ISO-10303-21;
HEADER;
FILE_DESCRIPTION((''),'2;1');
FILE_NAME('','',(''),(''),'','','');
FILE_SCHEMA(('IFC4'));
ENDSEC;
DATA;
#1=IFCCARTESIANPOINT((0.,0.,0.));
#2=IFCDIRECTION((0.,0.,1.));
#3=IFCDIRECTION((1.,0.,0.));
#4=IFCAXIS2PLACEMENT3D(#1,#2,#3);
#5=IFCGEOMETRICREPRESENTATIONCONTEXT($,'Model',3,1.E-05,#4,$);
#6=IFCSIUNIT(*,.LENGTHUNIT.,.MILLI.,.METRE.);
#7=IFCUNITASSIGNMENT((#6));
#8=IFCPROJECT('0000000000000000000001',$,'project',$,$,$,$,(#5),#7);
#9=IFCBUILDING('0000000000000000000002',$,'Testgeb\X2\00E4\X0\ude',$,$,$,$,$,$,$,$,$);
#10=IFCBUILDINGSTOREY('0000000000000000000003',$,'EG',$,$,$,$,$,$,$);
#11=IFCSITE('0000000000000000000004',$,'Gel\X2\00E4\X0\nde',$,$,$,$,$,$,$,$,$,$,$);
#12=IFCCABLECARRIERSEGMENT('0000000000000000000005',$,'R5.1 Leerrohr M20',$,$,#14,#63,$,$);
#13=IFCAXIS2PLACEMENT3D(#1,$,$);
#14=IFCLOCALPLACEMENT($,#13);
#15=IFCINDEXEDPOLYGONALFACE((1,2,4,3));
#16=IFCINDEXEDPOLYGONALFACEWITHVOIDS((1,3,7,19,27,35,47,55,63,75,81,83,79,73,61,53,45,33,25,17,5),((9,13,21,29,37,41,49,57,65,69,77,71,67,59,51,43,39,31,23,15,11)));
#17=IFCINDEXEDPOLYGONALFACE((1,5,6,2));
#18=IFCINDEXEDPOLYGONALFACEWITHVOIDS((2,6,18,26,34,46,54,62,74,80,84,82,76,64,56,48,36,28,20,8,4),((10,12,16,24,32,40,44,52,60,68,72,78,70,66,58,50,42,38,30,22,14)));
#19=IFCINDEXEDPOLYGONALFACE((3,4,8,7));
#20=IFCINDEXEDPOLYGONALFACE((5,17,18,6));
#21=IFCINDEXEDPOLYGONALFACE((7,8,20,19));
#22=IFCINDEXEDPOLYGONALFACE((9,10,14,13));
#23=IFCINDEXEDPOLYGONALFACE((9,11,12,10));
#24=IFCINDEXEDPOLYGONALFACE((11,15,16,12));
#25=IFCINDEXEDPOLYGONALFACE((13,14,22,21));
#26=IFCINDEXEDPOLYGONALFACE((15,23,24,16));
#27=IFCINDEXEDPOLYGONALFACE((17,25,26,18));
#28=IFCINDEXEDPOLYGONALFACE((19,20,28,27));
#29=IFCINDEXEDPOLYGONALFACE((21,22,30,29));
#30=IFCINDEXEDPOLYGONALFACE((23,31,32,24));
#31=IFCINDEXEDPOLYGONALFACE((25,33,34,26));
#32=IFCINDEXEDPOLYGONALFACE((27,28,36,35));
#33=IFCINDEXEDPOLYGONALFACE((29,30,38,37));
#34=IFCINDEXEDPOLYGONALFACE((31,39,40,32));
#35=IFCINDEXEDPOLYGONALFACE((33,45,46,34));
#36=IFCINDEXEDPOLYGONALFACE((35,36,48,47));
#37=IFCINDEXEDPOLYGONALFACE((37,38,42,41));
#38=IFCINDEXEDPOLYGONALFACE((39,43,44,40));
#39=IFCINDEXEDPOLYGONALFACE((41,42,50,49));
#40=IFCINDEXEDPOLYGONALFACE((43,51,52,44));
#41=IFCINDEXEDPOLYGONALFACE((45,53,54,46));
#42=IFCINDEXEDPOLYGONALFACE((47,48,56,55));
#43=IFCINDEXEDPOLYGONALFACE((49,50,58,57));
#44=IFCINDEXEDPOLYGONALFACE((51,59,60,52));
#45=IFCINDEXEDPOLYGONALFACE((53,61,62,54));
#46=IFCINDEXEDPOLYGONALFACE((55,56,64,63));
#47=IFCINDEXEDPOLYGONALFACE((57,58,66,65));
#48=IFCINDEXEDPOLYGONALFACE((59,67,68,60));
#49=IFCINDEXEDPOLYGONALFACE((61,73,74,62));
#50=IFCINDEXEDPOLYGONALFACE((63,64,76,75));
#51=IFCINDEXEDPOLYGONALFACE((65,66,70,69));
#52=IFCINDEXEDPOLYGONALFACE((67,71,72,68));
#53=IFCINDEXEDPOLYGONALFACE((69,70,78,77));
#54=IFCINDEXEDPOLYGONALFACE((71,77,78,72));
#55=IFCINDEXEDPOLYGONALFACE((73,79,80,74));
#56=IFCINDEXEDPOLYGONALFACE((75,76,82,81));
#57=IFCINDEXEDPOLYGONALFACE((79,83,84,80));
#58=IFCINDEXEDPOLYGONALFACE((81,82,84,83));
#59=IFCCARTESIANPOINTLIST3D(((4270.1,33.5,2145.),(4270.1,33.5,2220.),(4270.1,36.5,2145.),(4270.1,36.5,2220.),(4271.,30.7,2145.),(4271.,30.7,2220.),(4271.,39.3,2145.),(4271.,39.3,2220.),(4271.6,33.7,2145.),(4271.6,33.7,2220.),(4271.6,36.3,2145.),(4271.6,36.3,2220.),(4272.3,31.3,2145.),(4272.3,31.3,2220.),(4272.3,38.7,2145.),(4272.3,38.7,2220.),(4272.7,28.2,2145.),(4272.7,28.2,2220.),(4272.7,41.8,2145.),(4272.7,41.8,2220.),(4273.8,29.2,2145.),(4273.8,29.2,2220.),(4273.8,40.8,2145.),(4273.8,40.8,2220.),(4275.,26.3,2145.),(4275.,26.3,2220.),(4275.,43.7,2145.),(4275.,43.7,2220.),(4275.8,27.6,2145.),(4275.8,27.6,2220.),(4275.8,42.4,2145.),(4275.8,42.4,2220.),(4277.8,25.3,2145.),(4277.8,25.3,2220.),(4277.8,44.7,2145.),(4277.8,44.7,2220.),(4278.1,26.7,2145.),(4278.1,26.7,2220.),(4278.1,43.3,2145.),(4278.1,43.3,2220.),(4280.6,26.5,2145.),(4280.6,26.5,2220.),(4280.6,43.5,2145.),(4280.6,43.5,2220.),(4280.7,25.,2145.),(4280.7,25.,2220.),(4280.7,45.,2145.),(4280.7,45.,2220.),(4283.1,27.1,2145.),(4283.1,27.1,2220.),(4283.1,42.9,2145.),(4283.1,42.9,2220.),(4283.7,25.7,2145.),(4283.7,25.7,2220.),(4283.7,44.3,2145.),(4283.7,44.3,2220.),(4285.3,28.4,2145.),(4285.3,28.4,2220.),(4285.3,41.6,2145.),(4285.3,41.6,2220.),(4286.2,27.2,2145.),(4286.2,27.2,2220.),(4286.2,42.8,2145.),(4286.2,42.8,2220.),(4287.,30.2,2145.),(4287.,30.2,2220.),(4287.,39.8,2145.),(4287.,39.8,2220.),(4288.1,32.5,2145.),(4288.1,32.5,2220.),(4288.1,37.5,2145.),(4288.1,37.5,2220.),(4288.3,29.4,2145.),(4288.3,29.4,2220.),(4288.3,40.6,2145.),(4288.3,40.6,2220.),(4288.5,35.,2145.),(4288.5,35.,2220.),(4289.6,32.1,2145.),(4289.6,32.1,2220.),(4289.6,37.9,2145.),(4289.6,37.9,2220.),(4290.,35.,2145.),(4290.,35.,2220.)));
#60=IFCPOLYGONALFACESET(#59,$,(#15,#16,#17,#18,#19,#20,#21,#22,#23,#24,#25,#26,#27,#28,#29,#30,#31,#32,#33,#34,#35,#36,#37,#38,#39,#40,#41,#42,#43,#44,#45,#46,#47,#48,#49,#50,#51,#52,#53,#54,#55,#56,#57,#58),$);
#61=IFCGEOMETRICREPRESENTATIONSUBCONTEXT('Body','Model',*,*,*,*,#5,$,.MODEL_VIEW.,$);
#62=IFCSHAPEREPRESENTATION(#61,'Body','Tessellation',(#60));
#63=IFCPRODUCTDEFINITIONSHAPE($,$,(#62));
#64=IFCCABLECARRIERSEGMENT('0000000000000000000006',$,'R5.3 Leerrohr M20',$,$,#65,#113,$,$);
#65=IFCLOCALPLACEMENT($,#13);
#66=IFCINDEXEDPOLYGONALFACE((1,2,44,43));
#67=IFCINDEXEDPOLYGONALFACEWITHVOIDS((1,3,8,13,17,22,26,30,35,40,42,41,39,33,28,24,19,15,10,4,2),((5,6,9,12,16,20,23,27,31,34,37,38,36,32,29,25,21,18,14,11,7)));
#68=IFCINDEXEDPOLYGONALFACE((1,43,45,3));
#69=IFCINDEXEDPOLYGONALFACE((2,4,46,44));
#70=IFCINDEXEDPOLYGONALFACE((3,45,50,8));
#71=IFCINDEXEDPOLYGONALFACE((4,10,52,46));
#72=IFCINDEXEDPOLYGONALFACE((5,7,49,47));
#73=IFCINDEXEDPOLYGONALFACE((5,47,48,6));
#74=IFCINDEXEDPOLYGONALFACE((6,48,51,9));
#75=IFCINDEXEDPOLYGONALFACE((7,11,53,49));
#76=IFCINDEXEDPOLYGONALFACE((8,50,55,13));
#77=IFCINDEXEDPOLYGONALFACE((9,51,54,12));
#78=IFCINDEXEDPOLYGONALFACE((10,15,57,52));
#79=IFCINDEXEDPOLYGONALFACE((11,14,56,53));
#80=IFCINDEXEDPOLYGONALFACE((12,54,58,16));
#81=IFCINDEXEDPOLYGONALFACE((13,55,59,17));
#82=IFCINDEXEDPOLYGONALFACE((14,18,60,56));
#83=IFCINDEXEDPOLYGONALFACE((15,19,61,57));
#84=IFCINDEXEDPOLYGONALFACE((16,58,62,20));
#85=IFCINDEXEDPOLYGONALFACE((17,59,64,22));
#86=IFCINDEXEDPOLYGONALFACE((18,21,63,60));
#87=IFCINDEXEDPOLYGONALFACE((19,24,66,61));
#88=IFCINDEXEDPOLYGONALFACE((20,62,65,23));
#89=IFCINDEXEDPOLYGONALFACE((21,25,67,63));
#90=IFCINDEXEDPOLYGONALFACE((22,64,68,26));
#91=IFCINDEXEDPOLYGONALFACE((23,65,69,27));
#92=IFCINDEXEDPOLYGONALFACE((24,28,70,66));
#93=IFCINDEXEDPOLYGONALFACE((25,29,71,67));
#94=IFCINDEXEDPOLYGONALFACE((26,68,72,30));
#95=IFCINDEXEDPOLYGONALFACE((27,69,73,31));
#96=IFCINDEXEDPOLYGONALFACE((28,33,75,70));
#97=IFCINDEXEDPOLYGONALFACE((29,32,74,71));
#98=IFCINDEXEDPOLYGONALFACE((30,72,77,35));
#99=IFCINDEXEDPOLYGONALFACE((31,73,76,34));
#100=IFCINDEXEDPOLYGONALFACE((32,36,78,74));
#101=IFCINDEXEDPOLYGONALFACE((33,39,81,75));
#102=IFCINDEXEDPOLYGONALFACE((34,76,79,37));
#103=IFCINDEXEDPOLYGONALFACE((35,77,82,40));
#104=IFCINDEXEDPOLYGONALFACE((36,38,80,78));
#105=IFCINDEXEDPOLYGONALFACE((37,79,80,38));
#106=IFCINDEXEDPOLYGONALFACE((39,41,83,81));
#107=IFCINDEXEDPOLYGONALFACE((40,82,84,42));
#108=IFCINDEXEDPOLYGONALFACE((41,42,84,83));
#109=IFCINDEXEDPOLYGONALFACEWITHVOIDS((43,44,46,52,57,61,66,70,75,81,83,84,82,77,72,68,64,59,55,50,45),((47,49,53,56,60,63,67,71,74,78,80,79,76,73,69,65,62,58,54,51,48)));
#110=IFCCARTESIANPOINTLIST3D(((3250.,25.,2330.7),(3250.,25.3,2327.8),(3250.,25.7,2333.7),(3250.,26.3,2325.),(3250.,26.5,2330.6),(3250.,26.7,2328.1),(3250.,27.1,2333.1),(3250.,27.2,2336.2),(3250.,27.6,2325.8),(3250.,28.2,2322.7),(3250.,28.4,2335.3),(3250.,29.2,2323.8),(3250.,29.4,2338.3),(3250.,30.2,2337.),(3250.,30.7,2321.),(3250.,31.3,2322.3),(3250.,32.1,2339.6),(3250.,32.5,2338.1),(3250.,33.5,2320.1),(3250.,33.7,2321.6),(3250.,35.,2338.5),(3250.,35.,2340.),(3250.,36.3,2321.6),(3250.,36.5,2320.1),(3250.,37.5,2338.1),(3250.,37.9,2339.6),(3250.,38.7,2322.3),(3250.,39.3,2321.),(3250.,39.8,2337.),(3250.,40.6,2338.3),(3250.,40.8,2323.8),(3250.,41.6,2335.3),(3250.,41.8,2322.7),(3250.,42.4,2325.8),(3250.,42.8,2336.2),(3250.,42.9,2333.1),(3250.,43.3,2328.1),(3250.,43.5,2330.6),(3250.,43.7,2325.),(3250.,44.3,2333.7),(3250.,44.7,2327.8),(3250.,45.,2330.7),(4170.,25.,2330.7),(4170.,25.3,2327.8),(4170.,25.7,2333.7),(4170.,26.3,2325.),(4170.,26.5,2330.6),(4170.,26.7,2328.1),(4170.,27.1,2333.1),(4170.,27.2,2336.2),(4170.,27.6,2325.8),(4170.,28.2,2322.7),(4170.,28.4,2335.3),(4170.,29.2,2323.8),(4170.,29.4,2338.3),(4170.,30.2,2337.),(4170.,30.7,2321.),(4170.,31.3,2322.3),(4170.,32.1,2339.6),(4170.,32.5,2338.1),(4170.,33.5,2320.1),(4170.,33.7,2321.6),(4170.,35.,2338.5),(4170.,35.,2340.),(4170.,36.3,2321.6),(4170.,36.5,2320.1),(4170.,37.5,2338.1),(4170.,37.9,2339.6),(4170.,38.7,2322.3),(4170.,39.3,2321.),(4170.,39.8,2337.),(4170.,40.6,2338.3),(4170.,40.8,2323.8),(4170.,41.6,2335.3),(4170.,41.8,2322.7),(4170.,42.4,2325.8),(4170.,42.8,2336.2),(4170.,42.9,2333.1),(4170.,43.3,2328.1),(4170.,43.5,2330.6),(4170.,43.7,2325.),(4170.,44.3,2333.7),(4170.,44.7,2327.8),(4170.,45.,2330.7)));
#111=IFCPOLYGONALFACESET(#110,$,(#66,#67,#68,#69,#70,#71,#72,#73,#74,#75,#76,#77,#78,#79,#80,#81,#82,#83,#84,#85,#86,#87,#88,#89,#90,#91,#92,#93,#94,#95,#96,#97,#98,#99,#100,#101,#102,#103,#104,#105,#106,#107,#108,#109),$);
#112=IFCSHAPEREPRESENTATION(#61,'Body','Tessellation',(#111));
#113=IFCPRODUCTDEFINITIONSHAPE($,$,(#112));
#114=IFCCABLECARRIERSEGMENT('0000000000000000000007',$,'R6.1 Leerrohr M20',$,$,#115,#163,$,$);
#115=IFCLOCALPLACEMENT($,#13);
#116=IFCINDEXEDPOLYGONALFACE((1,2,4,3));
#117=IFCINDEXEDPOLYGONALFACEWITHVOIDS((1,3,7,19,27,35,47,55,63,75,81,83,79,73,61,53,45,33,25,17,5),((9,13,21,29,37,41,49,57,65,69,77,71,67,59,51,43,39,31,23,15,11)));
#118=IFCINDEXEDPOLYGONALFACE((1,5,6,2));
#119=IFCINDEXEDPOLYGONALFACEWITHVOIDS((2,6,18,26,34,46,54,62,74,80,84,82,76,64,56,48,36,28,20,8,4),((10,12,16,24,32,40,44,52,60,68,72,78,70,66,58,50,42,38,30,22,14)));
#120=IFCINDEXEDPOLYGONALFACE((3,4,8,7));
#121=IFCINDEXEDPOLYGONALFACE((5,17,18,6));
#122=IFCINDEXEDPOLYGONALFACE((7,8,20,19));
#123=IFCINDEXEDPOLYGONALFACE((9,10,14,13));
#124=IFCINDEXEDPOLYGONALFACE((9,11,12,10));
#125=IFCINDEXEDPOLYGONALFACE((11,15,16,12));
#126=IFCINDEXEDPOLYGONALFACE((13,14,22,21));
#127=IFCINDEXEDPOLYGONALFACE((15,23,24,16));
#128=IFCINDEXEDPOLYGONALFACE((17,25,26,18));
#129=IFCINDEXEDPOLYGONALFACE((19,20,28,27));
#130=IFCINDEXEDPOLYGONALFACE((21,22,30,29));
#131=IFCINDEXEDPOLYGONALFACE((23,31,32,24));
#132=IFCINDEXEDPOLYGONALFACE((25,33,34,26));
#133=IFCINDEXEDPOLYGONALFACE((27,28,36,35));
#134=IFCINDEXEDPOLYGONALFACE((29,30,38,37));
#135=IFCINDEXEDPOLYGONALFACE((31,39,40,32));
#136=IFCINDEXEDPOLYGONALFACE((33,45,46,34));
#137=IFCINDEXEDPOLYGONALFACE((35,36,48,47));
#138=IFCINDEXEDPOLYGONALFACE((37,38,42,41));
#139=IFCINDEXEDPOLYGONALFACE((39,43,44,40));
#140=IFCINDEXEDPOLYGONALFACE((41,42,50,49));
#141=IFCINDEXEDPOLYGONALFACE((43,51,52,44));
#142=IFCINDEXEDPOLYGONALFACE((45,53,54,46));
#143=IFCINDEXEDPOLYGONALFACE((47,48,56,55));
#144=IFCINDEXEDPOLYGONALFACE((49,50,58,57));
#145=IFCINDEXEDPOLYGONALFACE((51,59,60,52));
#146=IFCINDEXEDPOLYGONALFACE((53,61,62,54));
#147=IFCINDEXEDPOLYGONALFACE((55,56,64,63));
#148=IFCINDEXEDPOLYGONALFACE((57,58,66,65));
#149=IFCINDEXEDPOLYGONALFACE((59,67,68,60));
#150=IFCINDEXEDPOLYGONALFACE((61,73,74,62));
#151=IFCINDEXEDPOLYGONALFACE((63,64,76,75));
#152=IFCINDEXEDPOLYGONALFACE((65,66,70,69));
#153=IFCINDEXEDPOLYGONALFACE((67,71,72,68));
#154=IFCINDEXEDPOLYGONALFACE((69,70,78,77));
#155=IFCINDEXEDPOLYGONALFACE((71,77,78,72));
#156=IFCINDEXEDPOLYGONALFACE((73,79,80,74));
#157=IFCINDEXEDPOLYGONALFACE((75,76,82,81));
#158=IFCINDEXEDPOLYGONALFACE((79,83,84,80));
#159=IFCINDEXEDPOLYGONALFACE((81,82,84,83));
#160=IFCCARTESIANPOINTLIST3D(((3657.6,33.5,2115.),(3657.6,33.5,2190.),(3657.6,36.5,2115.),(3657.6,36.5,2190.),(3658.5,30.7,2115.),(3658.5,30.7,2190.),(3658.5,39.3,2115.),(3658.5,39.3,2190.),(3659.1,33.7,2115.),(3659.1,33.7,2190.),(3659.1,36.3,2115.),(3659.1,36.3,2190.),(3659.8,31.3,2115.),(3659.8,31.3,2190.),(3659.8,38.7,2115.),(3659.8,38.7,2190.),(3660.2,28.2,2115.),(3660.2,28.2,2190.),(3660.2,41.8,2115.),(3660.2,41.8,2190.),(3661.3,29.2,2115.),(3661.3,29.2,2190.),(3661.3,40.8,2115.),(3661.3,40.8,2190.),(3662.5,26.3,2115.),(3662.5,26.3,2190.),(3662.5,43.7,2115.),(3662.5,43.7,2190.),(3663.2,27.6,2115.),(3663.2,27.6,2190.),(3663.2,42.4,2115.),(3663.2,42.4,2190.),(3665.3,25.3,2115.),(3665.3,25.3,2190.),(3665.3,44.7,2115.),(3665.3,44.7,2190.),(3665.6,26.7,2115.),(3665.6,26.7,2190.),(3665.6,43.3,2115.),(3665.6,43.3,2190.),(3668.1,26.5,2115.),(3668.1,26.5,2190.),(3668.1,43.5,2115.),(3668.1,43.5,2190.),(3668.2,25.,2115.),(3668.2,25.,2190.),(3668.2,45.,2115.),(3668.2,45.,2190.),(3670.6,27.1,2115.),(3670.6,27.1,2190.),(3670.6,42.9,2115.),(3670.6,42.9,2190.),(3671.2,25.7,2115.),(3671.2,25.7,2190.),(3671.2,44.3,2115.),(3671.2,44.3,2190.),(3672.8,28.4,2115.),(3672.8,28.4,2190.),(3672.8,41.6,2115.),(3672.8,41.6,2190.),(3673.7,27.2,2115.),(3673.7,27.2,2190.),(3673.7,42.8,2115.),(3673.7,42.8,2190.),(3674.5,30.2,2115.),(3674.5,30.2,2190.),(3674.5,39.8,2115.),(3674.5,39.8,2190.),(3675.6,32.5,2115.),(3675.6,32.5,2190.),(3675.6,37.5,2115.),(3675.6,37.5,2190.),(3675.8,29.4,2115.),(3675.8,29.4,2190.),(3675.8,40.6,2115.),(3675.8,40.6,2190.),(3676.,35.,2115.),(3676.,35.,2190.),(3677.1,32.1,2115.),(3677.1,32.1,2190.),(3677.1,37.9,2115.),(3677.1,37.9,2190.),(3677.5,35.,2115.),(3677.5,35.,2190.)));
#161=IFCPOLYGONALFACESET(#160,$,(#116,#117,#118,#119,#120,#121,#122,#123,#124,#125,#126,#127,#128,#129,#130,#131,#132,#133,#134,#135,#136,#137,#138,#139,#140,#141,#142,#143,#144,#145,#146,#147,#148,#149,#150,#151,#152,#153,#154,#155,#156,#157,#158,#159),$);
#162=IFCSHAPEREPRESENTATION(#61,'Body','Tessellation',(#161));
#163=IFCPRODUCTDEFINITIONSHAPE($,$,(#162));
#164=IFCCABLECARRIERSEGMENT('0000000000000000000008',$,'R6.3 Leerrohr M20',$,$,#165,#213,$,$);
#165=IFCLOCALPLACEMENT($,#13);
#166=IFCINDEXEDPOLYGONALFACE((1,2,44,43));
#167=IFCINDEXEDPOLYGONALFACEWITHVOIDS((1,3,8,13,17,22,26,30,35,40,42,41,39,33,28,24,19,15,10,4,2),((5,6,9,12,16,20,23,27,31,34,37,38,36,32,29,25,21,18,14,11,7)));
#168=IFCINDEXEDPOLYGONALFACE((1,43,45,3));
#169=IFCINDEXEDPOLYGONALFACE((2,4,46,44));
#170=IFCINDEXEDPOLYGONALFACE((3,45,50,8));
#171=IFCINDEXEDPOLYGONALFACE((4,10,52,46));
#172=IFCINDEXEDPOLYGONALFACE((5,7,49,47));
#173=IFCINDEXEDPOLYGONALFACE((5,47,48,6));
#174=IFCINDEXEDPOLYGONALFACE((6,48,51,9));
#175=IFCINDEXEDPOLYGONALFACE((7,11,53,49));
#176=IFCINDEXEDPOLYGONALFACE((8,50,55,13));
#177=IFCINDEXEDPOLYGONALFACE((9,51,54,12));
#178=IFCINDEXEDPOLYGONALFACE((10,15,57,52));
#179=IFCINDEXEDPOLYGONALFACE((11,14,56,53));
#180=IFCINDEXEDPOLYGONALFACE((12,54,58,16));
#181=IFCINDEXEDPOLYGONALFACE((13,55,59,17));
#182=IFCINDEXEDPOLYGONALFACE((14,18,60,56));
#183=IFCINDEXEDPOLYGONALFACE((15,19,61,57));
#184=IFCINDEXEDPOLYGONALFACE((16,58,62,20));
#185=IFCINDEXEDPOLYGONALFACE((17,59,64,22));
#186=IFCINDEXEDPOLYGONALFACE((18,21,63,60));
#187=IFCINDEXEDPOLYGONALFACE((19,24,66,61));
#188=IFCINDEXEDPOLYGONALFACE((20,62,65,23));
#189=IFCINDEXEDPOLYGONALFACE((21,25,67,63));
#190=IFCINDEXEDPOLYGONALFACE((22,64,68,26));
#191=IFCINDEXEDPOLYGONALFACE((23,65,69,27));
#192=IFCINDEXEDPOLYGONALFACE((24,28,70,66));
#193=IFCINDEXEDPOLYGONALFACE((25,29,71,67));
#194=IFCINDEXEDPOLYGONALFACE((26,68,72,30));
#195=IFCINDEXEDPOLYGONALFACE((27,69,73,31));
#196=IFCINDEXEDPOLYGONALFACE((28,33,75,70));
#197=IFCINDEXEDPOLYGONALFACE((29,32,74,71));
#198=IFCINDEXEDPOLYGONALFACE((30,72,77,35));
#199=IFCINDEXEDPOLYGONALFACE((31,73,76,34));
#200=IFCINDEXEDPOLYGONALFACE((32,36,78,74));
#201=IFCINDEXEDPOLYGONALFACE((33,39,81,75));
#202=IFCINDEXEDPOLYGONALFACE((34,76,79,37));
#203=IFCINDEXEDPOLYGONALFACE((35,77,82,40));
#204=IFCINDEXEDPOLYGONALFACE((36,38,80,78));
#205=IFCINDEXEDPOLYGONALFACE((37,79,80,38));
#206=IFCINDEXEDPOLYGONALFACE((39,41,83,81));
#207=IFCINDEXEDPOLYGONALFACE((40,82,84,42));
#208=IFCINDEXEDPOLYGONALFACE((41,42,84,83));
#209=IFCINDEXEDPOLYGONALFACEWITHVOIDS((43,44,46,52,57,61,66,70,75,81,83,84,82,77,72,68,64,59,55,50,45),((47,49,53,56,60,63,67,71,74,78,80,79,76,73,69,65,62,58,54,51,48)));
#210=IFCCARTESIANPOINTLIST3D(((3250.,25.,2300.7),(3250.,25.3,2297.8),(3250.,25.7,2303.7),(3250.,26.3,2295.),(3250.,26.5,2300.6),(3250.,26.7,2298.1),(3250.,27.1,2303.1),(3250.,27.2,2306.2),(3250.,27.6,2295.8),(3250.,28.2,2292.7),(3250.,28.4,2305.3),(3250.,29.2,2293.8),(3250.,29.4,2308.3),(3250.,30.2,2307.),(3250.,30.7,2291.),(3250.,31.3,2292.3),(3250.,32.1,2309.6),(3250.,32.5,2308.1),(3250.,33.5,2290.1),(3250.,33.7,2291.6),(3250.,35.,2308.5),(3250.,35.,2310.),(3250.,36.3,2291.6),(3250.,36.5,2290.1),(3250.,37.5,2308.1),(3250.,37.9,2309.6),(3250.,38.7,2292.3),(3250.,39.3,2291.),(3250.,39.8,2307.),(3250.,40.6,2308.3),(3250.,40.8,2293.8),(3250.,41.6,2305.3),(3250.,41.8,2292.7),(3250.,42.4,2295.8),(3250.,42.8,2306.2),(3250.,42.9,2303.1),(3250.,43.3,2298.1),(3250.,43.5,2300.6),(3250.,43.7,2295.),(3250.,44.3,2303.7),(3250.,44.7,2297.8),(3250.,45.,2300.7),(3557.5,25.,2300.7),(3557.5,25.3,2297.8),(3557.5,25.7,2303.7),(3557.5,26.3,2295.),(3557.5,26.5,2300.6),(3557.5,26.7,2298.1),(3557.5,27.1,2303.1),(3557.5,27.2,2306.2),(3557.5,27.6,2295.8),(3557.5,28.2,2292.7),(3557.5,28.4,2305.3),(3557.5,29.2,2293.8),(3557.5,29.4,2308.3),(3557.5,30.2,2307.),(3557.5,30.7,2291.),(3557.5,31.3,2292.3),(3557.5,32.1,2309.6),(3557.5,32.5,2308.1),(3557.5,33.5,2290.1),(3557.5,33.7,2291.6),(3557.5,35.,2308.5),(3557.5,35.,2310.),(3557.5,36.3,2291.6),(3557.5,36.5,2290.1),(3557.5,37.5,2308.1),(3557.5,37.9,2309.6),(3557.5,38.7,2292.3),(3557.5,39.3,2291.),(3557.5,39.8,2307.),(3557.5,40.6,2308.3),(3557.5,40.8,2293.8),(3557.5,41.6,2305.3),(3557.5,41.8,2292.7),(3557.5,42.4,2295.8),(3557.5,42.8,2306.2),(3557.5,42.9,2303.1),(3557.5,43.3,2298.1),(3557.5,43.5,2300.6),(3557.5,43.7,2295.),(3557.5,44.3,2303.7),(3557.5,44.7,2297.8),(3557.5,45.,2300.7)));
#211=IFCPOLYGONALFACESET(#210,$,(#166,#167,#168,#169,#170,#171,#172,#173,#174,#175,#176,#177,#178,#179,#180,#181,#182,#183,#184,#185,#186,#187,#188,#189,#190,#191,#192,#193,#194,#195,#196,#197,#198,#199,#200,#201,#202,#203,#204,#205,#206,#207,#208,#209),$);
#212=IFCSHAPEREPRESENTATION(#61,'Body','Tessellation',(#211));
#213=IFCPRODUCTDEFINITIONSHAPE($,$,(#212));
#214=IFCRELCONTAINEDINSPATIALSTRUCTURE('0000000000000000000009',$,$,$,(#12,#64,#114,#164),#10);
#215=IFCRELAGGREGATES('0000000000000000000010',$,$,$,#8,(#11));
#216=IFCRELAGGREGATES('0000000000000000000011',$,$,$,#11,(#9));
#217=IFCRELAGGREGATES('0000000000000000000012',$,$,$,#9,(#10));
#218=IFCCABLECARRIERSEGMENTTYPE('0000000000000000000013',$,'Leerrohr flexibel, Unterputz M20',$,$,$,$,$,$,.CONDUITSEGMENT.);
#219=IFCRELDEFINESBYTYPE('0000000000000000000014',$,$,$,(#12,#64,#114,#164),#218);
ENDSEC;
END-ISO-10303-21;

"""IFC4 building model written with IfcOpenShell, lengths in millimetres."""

from ifc_helpers import new_model, si_unit, frame, origin_with_axes, place, context, subcontext, project, spatial, hollow_circle, extrude, type_object, element, save


model = new_model("IFC4")

# Units and contexts
model_context = context("Model", 3, precision=1e-05, world=origin_with_axes())
body_context = subcontext(model_context, "Body", "Model", "MODEL_VIEW")
ifc_project = project(units=[si_unit("LENGTHUNIT", "METRE", prefix="MILLI")], contexts=[model_context])

# Site, building, storey
site = spatial("IfcSite", under=ifc_project, Name="Gelände")
building = spatial("IfcBuilding", under=site, Name="Testgebäude")
storey = spatial("IfcBuildingStorey", under=building, Name="EG")

# Cable carrier segments
cable_carrier_segment_type_1 = type_object("IfcCableCarrierSegmentType", Name="Leerrohr flexibel, Unterputz M20", PredefinedType="CONDUITSEGMENT")
cable_carrier_segment_1_placement = place(None, frame((4280.0, 35.0, 2145.0), z_axis=(0.0, 0.0, 1.0), x_axis=(1.0, 0.0, 0.0)))
element("IfcCableCarrierSegment", 1, at=cable_carrier_segment_1_placement, inside=storey, type_object=cable_carrier_segment_type_1, Name="R5.1 Leerrohr M20", context=body_context, shape_type="SweptSolid", body=[
    extrude(hollow_circle(Radius=10.0, WallThickness=1.5), None, (0.0, 0.0, 1.0), 75.0),
])
cable_carrier_segment_2_placement = place(None, frame((4170.0, 35.0, 2330.0), z_axis=(-1.0, 0.0, 0.0), x_axis=(0.0, 0.0, 1.0)))
element("IfcCableCarrierSegment", 2, at=cable_carrier_segment_2_placement, inside=storey, type_object=cable_carrier_segment_type_1, Name="R5.3 Leerrohr M20", context=body_context, shape_type="SweptSolid", body=[
    extrude(hollow_circle(Radius=10.0, WallThickness=1.5), None, (0.0, 0.0, 1.0), 920.0),
])
cable_carrier_segment_3_placement = place(None, frame((3667.5, 35.0, 2115.0), z_axis=(0.0, 0.0, 1.0), x_axis=(1.0, 0.0, 0.0)))
element("IfcCableCarrierSegment", 3, at=cable_carrier_segment_3_placement, inside=storey, type_object=cable_carrier_segment_type_1, Name="R6.1 Leerrohr M20", context=body_context, shape_type="SweptSolid", body=[
    extrude(hollow_circle(Radius=10.0, WallThickness=1.5), None, (0.0, 0.0, 1.0), 75.0),
])
cable_carrier_segment_4_placement = place(None, frame((3557.5, 35.0, 2300.0), z_axis=(-1.0, 0.0, 0.0), x_axis=(0.0, 0.0, 1.0)))
element("IfcCableCarrierSegment", 4, at=cable_carrier_segment_4_placement, inside=storey, type_object=cable_carrier_segment_type_1, Name="R6.3 Leerrohr M20", context=body_context, shape_type="SweptSolid", body=[
    extrude(hollow_circle(Radius=10.0, WallThickness=1.5), None, (0.0, 0.0, 1.0), 307.5),
])

save(model, "model.ifc")
